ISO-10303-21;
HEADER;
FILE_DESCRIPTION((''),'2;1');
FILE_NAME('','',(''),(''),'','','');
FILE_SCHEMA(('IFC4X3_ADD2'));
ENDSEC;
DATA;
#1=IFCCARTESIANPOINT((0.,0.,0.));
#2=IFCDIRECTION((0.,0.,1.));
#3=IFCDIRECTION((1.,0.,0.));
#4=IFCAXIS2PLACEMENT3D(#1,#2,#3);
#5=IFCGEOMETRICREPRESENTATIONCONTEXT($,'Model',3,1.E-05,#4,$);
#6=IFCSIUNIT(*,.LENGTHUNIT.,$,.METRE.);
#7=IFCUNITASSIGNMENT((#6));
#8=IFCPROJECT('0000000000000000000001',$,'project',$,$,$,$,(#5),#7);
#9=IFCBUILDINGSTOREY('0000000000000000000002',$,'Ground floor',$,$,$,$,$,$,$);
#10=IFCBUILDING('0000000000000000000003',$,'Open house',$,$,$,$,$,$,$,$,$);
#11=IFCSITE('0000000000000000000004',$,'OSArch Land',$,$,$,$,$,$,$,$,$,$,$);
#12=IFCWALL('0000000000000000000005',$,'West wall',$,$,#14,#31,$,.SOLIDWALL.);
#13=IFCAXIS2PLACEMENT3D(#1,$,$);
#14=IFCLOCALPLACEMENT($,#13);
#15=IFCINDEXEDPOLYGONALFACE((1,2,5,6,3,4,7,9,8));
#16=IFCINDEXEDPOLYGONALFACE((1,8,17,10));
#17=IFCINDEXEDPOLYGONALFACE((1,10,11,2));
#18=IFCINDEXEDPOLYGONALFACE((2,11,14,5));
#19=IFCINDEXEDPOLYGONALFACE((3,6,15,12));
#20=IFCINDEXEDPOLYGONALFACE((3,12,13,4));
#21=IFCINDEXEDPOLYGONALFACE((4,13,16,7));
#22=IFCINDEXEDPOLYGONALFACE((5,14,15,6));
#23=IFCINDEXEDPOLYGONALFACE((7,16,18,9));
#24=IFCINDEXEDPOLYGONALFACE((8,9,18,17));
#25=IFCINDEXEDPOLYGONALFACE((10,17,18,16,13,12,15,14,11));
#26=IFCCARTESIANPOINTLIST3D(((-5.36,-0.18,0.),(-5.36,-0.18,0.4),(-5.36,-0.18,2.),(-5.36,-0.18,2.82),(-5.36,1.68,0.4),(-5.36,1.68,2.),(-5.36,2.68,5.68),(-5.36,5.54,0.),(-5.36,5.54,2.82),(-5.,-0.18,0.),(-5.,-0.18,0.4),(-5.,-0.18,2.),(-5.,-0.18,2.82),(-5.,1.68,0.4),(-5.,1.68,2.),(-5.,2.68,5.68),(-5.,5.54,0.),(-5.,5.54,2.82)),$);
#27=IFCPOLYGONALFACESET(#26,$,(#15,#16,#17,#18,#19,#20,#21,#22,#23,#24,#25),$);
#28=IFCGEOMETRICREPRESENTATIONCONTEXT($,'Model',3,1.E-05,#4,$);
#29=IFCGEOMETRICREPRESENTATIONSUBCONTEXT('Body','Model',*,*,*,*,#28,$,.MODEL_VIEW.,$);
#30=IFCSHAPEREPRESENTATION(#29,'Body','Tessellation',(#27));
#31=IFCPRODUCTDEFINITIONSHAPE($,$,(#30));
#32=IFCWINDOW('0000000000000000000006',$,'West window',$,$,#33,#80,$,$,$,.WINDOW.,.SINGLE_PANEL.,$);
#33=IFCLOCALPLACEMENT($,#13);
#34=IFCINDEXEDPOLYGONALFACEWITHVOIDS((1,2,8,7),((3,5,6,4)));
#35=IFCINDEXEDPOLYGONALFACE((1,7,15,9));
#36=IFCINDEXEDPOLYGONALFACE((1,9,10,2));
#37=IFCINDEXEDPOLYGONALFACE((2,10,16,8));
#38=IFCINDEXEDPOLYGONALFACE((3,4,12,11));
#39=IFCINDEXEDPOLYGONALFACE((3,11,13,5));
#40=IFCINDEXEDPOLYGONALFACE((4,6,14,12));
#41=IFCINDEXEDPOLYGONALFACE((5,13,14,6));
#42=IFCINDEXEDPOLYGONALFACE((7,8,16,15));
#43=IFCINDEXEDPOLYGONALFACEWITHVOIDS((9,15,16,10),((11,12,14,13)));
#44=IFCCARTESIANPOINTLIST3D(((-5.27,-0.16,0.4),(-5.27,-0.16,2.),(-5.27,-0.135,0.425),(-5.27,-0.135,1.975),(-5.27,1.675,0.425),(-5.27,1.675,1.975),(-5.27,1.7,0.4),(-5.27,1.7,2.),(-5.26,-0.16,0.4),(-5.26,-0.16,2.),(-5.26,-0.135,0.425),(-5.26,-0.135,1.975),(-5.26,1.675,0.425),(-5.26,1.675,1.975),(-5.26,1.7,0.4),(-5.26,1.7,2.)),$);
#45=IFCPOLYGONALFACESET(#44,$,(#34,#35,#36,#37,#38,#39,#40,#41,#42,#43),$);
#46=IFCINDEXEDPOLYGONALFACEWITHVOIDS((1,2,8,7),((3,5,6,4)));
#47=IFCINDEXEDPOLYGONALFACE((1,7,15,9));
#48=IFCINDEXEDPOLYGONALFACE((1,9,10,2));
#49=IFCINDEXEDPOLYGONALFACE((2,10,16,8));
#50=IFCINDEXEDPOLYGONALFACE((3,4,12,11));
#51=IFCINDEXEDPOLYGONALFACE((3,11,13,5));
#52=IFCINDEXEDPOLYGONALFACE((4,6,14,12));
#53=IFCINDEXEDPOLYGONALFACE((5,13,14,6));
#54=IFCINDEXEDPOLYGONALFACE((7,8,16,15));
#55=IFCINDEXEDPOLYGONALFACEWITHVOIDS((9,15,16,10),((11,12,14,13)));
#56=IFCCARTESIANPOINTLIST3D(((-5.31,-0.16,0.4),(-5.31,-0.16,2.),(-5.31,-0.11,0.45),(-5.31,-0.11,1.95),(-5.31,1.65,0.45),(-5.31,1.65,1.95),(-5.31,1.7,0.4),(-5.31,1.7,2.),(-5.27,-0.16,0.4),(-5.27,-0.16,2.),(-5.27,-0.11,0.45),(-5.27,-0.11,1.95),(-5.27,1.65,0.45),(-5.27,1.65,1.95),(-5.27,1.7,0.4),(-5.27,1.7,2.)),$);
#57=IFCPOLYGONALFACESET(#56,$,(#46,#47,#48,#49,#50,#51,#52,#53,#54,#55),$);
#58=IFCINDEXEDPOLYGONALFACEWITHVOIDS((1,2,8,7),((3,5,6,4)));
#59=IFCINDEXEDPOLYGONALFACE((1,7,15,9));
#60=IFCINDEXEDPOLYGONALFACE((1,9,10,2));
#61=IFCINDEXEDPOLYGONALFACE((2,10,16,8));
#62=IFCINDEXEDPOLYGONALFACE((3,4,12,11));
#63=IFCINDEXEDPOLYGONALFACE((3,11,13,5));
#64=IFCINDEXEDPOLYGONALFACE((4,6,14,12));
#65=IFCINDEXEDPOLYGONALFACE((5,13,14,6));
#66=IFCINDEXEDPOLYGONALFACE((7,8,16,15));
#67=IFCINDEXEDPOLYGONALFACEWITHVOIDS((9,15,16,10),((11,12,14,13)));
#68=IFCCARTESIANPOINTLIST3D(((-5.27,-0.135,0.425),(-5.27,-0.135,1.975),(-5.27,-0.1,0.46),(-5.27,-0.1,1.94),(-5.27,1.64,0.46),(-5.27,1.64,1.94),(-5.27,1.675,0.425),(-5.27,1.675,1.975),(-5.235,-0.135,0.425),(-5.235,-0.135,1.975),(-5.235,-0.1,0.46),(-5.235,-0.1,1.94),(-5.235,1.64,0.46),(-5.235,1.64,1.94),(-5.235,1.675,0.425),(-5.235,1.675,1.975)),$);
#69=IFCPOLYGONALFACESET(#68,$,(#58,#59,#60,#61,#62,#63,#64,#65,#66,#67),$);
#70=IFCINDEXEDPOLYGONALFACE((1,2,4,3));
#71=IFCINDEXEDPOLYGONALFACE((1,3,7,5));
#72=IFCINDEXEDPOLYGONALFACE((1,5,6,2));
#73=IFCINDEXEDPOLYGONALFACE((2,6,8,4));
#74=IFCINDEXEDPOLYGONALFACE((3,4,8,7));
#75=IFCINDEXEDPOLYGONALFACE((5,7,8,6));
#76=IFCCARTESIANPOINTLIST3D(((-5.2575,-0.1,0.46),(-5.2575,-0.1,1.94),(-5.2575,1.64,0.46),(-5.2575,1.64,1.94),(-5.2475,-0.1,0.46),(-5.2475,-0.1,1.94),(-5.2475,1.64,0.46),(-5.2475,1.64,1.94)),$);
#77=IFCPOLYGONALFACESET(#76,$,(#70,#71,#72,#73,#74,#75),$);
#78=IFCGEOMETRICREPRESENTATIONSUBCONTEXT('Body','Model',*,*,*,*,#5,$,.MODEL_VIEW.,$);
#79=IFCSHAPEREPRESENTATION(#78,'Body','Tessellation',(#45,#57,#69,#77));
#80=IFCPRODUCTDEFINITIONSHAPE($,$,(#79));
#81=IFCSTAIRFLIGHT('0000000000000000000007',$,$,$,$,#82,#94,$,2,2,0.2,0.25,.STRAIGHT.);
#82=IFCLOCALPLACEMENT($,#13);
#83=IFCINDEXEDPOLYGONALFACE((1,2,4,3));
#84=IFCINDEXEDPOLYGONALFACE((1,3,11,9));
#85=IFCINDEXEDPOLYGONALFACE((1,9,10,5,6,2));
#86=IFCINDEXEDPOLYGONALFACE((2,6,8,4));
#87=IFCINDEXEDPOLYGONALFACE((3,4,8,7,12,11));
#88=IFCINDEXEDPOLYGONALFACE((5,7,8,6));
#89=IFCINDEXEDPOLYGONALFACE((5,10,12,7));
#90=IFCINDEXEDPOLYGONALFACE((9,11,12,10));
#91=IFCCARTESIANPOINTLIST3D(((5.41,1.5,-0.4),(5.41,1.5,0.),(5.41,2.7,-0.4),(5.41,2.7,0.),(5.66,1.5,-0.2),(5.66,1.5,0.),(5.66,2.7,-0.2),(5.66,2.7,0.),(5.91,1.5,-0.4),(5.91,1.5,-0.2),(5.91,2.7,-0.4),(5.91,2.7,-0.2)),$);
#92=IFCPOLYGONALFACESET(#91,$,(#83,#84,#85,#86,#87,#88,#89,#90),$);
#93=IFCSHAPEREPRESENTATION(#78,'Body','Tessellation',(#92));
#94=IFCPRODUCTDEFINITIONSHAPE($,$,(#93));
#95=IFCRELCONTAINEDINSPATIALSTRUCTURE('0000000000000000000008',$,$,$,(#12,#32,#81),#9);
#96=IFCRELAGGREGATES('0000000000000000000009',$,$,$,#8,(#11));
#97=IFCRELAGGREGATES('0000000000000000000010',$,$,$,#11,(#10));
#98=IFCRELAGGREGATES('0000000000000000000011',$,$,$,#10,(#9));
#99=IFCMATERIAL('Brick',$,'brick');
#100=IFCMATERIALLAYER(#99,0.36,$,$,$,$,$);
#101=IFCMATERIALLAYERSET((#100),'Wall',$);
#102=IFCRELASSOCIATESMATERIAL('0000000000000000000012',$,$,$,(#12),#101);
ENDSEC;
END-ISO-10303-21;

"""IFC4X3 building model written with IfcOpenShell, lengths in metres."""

from ifc_helpers import new_model, si_unit, frame, origin_with_axes, place, context, subcontext, project, spatial, line, indexed_curve, outline, extrude, clip, halfspace, material, layer, layer_set, layer_usage, element, fill, save


model = new_model("IFC4X3")

# Units and contexts
model_context_1 = context("Model", 3, precision=1e-05, world=origin_with_axes())
model_context_2 = context("Model", 3, precision=1e-05, world=origin_with_axes())
model_context_3 = context("Model", 3, precision=1e-05, world=origin_with_axes())
body_context_1 = subcontext(model_context_1, "Body", "Model", "MODEL_VIEW")
body_context_2 = subcontext(model_context_2, "Body", "Model", "MODEL_VIEW")
body_context_3 = subcontext(model_context_3, "Body", "Model", "MODEL_VIEW")
ifc_project = project(units=[si_unit("LENGTHUNIT", "METRE")], contexts=[model_context_1])

# Site, building, storey
site = spatial("IfcSite", under=ifc_project, Name="OSArch Land")
building = spatial("IfcBuilding", under=site, Name="Open house")
storey = spatial("IfcBuildingStorey", under=building, Name="Ground floor")

# Shared definitions
ifc_material = material(Name="Brick", Category="brick")
ifc_layer = layer(ifc_material, 0.36)
ifc_layer_set = layer_set([ifc_layer], Name="Wall")

# Wall, opening, window
ifc_layer_usage_1 = layer_usage(ifc_layer_set, "AXIS2", "POSITIVE", 0.0)
wall_1_placement = place(None, frame((-5.36, -0.18, 0.0), z_axis=(0.0, 0.0, 1.0), x_axis=(1.0, 0.0, 0.0)))
wall_1 = element("IfcWall", 1, at=wall_1_placement, inside=storey, material=ifc_layer_usage_1, Name="West wall", PredefinedType="SOLIDWALL", context=body_context_2, shape_type="Clipping", body=[
    clip(clip(extrude(outline(indexed_curve([(0.0, 0.0), (0.0, 5.72), (0.36, 5.72), (0.36, 0.0), (0.0, 0.0)], self_intersect=False)), origin_with_axes(), (0.0, 0.0, 1.0), 6.08), halfspace(frame((0.0, 5.54, 3.0), z_axis=(0.0, 0.707107, 0.707107), x_axis=(1.0, 0.0, 0.0)), False)), halfspace(frame((0.0, 0.18, 3.0), z_axis=(0.0, -0.707107, 0.707107), x_axis=(1.0, 0.0, 0.0)), False)),
])
opening_1_placement = place(wall_1_placement, frame((-0.09, -1.5, 0.4), z_axis=(0.0, 0.0, 1.0), x_axis=(1.0, 0.0, 0.0)))
opening_1 = element("IfcOpeningElement", 2, at=opening_1_placement, cuts=wall_1, context=body_context_3, shape_type="SweptSolid", body=[
    extrude(outline(indexed_curve([(0.0, 0.0), (0.0, 3.36), (6.05, 3.36), (6.05, 0.0), (0.0, 0.0)], self_intersect=False)), origin_with_axes(), (0.0, 0.0, 1.0), 1.6),
])
window_1_placement = place(None, frame((-5.36, 1.7, 0.4), z_axis=(0.0, 0.0, 1.0), x_axis=(0.0, -1.0, 0.0)))
window_1 = element("IfcWindow", 3, at=window_1_placement, inside=storey, Name="West window", PartitioningType="SINGLE_PANEL", PredefinedType="WINDOW", context=body_context_1, shape_type="SweptSolid", body=[
    extrude(outline(indexed_curve([(0.0, 0.0, 0.0), (1.86, 0.0, 0.0), (1.86, 0.0, 1.6), (0.0, 0.0, 1.6)], segments=[line(1, 2), line(2, 3), line(3, 4), line(4, 1)]), holes=[indexed_curve([(0.025, 0.0, 0.025), (1.835, 0.0, 0.025), (1.835, 0.0, 1.575), (0.025, 0.0, 1.575)], segments=[line(1, 2), line(2, 3), line(3, 4), line(4, 1)])]), frame((0.0, 0.09, 0.0), z_axis=(0.0, 0.0, 1.0), x_axis=(1.0, 0.0, 0.0)), (0.0, 1.0, 0.0), 0.01),
    extrude(outline(indexed_curve([(0.0, 0.0, 0.0), (1.86, 0.0, 0.0), (1.86, 0.0, 1.6), (0.0, 0.0, 1.6)], segments=[line(1, 2), line(2, 3), line(3, 4), line(4, 1)]), holes=[indexed_curve([(0.05, 0.0, 0.05), (1.81, 0.0, 0.05), (1.81, 0.0, 1.55), (0.05, 0.0, 1.55)], segments=[line(1, 2), line(2, 3), line(3, 4), line(4, 1)])]), frame((0.0, 0.05, 0.0), z_axis=(0.0, 0.0, 1.0), x_axis=(1.0, 0.0, 0.0)), (0.0, 1.0, 0.0), 0.04),
    extrude(outline(indexed_curve([(0.0, 0.0, 0.0), (1.81, 0.0, 0.0), (1.81, 0.0, 1.55), (0.0, 0.0, 1.55)], segments=[line(1, 2), line(2, 3), line(3, 4), line(4, 1)]), holes=[indexed_curve([(0.035, 0.0, 0.035), (1.775, 0.0, 0.035), (1.775, 0.0, 1.515), (0.035, 0.0, 1.515)], segments=[line(1, 2), line(2, 3), line(3, 4), line(4, 1)])]), frame((0.025, 0.09, 0.025), z_axis=(0.0, 0.0, 1.0), x_axis=(1.0, 0.0, 0.0)), (0.0, 1.0, 0.0), 0.035),
    extrude(outline(indexed_curve([(0.035, 0.0, 0.035), (1.775, 0.0, 0.035), (1.775, 0.0, 1.515), (0.035, 0.0, 1.515)], segments=[line(1, 2), line(2, 3), line(3, 4), line(4, 1)])), frame((0.025, 0.1025, 0.025), z_axis=(0.0, 0.0, 1.0), x_axis=(1.0, 0.0, 0.0)), (0.0, 1.0, 0.0), 0.01),
])
fill(opening_1, window_1)

# Stair flight
stair_flight_placement = place(None, frame((5.41, 1.5, 0.0), z_axis=(0.0, 1.0, 0.0), x_axis=(1.0, 0.0, 0.0)))
element("IfcStairFlight", 4, at=stair_flight_placement, inside=storey, NumberOfRisers=2, NumberOfTreads=2, PredefinedType="STRAIGHT", RiserHeight=0.2, TreadLength=0.25, context=body_context_1, shape_type="SweptSolid", body=[
    extrude(outline(indexed_curve([(0.0, 0.0), (0.25, 0.0), (0.25, 0.2), (0.5, 0.2), (0.5, 0.4), (0.0, 0.4)], self_intersect=False)), origin_with_axes(), (0.0, 0.0, 1.0), 1.2),
])

save(model, "model.ifc")
